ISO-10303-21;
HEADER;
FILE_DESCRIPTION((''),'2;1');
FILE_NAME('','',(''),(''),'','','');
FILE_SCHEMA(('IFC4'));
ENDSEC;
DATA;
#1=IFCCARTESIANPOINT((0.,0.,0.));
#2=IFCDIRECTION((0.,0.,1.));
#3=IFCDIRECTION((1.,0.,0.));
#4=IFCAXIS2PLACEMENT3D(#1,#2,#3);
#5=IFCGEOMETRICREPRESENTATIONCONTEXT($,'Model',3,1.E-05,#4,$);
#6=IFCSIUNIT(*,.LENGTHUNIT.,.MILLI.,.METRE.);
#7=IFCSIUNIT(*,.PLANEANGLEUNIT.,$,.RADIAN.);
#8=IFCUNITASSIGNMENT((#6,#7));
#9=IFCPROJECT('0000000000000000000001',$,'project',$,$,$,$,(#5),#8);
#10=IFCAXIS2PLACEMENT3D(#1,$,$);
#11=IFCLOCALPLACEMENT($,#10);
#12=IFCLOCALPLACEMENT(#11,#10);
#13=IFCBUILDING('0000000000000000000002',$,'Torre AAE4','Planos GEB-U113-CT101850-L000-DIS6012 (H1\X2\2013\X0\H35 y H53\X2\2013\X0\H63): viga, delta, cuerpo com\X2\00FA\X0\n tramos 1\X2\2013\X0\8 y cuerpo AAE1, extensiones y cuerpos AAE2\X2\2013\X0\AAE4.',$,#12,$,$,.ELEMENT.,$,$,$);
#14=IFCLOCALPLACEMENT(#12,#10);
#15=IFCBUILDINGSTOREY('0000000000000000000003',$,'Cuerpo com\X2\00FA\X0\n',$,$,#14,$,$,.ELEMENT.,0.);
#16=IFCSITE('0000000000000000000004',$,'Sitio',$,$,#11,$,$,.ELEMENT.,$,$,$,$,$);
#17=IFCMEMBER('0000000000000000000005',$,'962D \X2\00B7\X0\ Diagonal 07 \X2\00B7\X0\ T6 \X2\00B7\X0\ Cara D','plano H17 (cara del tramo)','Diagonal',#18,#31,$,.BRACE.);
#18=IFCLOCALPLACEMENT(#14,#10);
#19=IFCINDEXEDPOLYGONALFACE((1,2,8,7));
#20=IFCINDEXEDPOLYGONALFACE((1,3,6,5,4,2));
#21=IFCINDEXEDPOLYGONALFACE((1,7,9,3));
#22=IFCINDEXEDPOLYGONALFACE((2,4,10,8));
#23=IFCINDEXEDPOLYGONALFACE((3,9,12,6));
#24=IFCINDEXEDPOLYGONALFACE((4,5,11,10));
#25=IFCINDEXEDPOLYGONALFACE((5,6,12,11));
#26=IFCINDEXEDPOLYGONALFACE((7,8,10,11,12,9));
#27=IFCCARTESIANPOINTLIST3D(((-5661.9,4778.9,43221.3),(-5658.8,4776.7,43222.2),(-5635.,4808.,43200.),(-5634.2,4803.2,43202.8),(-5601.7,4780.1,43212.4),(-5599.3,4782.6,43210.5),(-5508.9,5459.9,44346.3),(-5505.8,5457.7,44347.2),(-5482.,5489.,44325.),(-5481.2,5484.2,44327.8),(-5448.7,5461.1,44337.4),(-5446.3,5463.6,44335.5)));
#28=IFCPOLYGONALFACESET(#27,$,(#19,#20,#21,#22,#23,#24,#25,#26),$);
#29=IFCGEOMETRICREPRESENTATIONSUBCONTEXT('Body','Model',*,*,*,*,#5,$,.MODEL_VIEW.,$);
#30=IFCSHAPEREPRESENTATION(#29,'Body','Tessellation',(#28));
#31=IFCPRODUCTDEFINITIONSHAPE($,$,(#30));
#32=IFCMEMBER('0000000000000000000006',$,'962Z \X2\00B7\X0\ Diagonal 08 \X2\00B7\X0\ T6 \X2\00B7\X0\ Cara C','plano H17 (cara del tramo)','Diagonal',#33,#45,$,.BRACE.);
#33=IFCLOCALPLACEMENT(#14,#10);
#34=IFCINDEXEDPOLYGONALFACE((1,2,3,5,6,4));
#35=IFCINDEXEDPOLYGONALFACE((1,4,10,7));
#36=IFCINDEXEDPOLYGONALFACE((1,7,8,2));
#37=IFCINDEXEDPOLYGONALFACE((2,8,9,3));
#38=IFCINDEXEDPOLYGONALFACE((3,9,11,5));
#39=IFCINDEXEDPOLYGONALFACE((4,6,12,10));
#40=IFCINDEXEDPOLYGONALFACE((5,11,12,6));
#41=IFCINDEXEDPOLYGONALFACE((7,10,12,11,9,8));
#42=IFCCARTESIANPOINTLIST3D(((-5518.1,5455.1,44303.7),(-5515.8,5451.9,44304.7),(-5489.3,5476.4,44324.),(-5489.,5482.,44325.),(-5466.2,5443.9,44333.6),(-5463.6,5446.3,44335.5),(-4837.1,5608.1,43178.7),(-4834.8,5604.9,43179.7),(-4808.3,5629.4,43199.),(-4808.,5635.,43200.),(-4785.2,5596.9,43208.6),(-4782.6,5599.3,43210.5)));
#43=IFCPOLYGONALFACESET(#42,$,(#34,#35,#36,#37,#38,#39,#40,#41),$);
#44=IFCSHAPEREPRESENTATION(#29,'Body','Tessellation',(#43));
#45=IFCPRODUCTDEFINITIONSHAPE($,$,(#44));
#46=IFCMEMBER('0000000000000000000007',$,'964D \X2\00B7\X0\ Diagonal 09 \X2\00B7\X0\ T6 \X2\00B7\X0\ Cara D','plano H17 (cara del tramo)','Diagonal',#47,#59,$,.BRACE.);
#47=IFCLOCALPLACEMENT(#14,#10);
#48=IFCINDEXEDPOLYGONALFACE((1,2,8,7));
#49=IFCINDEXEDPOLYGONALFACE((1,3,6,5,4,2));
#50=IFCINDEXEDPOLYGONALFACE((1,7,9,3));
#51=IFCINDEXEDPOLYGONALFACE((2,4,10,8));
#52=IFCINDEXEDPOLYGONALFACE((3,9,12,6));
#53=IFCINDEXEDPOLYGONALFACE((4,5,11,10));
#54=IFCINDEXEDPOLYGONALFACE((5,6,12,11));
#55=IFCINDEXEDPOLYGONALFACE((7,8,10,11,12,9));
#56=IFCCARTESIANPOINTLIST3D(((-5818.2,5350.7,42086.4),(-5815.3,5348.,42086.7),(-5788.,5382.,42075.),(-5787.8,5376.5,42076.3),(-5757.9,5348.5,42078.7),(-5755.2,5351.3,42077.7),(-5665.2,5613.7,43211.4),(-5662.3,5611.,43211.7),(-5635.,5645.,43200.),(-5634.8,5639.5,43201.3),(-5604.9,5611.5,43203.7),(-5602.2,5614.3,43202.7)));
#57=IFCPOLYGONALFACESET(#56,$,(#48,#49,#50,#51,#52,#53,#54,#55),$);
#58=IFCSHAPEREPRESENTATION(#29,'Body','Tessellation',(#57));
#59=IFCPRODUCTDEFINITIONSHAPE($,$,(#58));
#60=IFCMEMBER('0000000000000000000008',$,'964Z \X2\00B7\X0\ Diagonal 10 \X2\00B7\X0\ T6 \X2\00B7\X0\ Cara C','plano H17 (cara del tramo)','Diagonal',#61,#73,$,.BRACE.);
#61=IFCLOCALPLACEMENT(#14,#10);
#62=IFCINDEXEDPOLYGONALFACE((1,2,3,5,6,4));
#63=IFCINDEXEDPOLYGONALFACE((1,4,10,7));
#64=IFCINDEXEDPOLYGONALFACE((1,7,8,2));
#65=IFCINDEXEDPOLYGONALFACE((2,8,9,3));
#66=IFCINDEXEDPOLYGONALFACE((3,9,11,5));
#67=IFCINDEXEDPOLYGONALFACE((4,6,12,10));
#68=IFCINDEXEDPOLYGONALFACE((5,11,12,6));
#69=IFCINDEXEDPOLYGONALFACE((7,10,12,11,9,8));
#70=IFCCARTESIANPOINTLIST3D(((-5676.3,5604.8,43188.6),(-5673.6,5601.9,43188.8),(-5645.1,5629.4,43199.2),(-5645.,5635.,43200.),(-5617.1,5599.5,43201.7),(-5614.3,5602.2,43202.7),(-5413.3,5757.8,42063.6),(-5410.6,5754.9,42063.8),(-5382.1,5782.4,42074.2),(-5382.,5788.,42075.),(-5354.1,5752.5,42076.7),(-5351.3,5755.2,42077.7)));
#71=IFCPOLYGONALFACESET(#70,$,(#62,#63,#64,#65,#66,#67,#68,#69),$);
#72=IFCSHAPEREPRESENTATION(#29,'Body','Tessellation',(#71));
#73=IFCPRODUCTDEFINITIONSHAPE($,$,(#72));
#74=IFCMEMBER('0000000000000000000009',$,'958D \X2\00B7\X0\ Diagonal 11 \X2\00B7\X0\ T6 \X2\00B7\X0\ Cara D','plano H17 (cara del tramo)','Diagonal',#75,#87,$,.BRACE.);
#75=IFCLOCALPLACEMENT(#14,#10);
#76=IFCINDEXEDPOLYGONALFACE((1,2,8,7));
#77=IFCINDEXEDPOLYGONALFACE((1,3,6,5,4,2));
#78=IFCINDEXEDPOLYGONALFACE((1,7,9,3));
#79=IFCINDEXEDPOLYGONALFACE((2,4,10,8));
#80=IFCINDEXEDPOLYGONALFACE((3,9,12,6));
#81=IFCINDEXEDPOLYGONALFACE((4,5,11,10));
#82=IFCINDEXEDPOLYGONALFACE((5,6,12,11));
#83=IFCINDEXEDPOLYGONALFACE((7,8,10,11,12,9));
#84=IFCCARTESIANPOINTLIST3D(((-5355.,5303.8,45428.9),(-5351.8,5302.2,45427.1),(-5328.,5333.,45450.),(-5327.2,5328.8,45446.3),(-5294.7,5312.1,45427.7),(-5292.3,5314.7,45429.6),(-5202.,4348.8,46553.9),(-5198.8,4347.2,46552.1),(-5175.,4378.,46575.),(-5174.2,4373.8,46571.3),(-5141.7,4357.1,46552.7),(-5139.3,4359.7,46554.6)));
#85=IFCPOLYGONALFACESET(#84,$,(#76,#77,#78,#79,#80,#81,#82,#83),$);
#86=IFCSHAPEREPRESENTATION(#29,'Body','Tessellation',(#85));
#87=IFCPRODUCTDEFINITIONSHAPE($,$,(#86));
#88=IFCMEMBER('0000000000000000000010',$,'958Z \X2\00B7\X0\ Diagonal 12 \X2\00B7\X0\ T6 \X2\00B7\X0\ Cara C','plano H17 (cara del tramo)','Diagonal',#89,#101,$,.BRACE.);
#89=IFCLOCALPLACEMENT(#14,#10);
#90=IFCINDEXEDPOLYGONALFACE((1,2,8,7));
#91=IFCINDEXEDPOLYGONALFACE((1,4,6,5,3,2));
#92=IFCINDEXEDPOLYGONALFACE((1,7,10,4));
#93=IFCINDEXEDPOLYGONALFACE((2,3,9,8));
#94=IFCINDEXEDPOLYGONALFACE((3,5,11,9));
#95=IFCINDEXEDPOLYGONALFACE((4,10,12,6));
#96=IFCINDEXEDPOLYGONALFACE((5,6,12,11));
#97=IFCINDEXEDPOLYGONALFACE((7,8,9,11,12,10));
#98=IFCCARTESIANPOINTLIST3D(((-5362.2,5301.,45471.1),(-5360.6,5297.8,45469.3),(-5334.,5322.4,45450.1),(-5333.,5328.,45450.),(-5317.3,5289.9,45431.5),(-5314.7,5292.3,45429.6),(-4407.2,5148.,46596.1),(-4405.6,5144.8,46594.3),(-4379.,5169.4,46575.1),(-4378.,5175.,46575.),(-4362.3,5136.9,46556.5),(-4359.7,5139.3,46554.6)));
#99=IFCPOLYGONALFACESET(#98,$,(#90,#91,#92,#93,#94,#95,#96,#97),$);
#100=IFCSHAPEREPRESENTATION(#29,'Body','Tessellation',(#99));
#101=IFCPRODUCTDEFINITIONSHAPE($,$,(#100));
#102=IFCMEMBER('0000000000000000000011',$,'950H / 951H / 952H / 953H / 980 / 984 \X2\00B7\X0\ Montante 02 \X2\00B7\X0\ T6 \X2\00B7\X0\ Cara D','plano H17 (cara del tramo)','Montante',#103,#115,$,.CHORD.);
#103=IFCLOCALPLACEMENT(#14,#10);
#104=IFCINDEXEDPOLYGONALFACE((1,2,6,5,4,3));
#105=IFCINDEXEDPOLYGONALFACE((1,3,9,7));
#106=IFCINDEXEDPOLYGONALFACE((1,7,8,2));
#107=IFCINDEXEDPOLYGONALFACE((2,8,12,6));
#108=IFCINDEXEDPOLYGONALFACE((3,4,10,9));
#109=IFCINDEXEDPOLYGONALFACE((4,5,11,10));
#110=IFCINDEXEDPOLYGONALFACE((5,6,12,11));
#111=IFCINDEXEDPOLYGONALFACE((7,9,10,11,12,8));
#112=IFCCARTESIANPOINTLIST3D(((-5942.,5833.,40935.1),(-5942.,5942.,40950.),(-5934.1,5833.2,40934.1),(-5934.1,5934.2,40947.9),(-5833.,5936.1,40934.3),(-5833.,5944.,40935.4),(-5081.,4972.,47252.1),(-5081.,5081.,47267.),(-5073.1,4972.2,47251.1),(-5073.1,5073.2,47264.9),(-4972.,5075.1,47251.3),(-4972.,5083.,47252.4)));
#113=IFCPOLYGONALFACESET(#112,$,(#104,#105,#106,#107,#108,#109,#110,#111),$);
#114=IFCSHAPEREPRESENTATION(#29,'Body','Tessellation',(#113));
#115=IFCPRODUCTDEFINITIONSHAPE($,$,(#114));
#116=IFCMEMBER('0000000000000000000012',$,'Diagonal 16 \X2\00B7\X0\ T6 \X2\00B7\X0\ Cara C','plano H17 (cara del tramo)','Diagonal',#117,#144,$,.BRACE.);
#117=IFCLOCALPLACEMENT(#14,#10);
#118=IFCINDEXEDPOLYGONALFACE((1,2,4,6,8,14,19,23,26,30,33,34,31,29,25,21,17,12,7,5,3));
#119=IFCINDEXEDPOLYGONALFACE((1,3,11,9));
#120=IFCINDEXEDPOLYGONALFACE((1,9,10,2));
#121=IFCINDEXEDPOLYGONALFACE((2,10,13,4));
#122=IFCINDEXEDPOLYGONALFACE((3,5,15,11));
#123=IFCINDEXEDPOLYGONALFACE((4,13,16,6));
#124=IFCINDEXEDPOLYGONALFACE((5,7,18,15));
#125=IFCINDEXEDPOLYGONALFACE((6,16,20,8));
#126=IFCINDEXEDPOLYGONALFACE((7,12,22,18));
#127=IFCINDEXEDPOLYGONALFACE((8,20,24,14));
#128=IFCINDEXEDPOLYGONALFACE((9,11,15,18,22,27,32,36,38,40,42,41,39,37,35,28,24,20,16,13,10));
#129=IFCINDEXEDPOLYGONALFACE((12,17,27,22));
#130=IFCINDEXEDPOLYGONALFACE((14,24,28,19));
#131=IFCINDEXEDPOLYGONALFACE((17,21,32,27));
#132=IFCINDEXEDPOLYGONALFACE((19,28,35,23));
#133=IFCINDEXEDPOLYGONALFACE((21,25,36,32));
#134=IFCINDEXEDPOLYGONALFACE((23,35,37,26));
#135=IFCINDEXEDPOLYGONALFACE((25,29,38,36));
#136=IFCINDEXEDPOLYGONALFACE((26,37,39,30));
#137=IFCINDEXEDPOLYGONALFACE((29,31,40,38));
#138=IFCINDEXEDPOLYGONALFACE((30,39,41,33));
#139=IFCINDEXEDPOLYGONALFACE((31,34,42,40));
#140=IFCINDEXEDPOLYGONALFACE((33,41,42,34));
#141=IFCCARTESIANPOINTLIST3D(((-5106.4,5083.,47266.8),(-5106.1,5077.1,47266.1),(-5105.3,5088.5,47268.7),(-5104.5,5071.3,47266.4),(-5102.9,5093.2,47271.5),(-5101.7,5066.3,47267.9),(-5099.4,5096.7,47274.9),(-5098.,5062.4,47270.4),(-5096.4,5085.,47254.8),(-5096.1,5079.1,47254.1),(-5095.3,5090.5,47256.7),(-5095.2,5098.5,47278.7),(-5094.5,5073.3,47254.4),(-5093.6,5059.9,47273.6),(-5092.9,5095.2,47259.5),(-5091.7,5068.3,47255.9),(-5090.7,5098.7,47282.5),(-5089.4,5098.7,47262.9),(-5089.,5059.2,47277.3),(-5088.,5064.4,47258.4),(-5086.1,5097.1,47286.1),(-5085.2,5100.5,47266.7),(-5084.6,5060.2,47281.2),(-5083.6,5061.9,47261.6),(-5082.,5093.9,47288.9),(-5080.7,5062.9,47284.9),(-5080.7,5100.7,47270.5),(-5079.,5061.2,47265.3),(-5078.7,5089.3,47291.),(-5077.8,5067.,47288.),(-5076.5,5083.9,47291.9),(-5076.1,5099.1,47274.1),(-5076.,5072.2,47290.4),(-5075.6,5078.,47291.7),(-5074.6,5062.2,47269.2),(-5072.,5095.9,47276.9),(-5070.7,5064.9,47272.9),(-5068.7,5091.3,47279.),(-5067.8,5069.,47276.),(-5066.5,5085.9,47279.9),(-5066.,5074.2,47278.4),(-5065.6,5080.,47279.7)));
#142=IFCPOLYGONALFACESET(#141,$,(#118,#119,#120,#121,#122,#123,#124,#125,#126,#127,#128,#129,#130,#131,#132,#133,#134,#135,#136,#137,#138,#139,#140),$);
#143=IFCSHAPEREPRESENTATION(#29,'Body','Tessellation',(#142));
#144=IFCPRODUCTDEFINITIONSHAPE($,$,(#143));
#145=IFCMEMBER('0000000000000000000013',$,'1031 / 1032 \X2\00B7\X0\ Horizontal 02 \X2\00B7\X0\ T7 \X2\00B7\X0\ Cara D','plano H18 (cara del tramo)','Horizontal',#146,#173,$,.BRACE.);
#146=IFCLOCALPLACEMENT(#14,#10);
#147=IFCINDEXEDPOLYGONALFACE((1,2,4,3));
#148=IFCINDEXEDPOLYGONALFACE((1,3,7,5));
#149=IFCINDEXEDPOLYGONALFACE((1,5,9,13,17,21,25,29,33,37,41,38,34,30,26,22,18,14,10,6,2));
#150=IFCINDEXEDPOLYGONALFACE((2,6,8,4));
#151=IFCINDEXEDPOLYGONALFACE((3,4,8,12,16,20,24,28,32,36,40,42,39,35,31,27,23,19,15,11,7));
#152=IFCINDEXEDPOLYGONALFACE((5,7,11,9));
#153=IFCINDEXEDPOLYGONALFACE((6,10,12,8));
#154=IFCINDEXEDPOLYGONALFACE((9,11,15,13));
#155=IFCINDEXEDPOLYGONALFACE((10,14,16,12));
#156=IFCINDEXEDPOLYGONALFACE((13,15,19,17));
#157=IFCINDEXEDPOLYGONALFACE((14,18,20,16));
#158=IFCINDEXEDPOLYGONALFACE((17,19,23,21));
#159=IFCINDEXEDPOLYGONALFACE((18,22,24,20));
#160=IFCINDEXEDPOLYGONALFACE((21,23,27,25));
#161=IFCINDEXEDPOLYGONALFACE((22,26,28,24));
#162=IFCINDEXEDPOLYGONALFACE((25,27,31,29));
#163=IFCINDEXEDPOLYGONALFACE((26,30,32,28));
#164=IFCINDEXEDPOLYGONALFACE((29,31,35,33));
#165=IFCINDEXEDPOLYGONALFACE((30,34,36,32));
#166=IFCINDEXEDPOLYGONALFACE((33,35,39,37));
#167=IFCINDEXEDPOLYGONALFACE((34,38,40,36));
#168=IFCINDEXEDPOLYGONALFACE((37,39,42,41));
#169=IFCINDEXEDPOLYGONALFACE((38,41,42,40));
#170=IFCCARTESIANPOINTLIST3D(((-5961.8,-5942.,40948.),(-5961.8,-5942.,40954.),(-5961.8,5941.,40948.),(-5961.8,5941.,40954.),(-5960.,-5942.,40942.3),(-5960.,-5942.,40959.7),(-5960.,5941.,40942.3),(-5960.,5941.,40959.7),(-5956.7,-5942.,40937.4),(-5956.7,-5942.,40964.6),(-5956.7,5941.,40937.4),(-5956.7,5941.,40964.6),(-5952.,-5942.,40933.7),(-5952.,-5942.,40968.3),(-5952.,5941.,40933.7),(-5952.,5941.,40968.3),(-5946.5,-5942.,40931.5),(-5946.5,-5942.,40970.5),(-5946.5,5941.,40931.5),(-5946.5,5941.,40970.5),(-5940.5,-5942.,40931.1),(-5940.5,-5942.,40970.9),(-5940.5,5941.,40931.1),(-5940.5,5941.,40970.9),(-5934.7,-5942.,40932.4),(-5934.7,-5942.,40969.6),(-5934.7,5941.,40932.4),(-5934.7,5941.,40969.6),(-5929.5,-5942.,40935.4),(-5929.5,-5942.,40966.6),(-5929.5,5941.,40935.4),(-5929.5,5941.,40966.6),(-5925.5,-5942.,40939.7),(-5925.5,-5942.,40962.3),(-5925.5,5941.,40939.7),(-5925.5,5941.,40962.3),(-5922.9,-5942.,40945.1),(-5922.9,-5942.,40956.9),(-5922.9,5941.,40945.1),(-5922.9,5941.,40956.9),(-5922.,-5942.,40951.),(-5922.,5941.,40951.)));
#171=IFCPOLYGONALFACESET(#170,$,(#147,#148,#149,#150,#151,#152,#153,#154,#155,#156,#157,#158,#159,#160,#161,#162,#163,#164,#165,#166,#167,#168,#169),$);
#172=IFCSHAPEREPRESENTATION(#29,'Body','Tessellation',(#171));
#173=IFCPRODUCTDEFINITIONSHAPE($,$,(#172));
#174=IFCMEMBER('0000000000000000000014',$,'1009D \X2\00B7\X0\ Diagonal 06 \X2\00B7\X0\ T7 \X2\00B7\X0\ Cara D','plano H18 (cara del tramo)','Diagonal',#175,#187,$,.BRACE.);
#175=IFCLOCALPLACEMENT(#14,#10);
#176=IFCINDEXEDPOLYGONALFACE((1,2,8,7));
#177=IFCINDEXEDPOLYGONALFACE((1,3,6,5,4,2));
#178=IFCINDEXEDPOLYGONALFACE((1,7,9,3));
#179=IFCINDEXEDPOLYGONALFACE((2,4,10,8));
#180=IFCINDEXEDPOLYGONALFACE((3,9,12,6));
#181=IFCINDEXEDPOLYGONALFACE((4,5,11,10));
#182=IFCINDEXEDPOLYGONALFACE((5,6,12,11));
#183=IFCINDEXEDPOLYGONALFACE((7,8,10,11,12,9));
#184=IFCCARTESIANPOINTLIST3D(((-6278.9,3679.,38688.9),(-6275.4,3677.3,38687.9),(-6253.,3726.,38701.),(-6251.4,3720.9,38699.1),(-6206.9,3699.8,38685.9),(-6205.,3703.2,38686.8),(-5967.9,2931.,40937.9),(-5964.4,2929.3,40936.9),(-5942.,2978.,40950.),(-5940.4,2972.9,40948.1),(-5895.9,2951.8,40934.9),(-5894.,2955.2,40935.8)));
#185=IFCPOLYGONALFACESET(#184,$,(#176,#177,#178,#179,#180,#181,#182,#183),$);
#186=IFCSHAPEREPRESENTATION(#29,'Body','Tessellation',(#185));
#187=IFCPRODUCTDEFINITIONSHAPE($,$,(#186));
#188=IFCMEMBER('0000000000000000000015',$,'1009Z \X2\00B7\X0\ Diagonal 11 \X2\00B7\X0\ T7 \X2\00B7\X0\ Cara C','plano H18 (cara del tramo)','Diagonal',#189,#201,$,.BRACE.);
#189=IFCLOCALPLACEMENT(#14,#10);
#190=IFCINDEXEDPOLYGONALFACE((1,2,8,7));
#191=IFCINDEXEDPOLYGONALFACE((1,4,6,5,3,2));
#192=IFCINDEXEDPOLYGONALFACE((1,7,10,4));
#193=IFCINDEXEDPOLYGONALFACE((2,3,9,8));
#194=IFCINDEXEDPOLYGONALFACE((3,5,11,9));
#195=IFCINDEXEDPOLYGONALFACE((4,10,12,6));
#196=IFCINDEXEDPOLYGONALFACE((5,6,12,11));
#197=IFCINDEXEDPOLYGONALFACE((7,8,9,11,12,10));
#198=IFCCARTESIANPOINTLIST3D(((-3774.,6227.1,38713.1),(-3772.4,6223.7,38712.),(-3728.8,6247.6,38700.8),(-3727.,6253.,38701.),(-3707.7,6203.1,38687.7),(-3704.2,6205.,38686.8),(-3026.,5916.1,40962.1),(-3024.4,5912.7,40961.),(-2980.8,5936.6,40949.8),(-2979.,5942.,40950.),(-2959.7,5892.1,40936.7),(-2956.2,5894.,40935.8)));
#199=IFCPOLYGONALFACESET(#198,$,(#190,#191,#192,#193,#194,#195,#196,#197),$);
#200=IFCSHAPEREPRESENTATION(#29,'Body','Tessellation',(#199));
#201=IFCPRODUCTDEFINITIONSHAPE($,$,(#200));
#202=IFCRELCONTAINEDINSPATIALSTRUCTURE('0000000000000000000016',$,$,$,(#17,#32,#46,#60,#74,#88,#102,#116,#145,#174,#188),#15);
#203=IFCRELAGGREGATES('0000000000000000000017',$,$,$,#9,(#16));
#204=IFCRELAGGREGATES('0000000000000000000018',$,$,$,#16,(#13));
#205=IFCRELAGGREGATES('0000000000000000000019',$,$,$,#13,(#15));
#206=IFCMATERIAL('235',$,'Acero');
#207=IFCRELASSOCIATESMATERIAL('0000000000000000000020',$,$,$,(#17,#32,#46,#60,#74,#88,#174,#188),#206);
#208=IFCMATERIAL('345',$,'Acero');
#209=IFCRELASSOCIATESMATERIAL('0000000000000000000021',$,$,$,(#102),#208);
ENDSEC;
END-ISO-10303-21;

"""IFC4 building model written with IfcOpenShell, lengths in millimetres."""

from ifc_helpers import new_model, si_unit, frame, frame_2d, origin, origin_with_axes, place, context, subcontext, project, spatial, circle, l_section, extrude, material, element, save


model = new_model("IFC4")

# Units and contexts
model_context = context("Model", 3, precision=1e-05, world=origin_with_axes())
body_context = subcontext(model_context, "Body", "Model", "MODEL_VIEW")
ifc_project = project(units=[si_unit("LENGTHUNIT", "METRE", prefix="MILLI"), si_unit("PLANEANGLEUNIT", "RADIAN")], contexts=[model_context])

# Site, building, storey
site_placement = place(None, origin())
site = spatial("IfcSite", under=ifc_project, at=site_placement, Name="Sitio", CompositionType="ELEMENT")
building_placement = place(site_placement, origin())
building = spatial("IfcBuilding", under=site, at=building_placement, Name="Torre AAE4", Description="Planos GEB-U113-CT101850-L000-DIS6012 (H1–H35 y H53–H63): viga, delta, cuerpo común tramos 1–8 y cuerpo AAE1, extensiones y cuerpos AAE2–AAE4.", CompositionType="ELEMENT")
storey_placement = place(building_placement, origin())
storey = spatial("IfcBuildingStorey", under=building, at=storey_placement, Name="Cuerpo común", CompositionType="ELEMENT", Elevation=0.0)

# Members
ifc_material_1 = material(Name="235", Category="Acero")
for number, where, z_axis, x_axis, name in (
    (1, (-5482.0, 5489.0, 44325.0), (-0.115565, -0.514377, -0.849742), (0.792522, -0.563456, 0.233295), "962D · Diagonal 07 · T6 · Cara D"),
    (2, (-5489.0, 5482.0, 44325.0), (0.514377, 0.115565, -0.849742), (0.563456, -0.792522, 0.233295), "962Z · Diagonal 08 · T6 · Cara C"),
):
    element("IfcMember", number, at=place(storey_placement, frame(where, z_axis=z_axis, x_axis=x_axis)), inside=storey, material=ifc_material_1, Name=name, Description="plano H17 (cara del tramo)", ObjectType="Diagonal", PredefinedType="BRACE", context=body_context, shape_type="SweptSolid", body=[
        extrude(l_section(Depth=45.0, Width=45.0, Thickness=4.0, at=frame_2d((22.5, 22.5))), None, (0.0, 0.0, 1.0), 1323.9),
    ])
for number, where, z_axis, x_axis, name in (
    (3, (-5635.0, 5645.0, 43200.0), (-0.131283, -0.22567, -0.965318), (0.729059, -0.681795, 0.060236), "964D · Diagonal 09 · T6 · Cara D"),
    (4, (-5645.0, 5635.0, 43200.0), (0.22567, 0.131283, -0.965318), (0.681795, -0.729059, 0.060236), "964Z · Diagonal 10 · T6 · Cara C"),
):
    element("IfcMember", number, at=place(storey_placement, frame(where, z_axis=z_axis, x_axis=x_axis)), inside=storey, material=ifc_material_1, Name=name, Description="plano H17 (cara del tramo)", ObjectType="Diagonal", PredefinedType="BRACE", context=body_context, shape_type="SweptSolid", body=[
        extrude(l_section(Depth=45.0, Width=45.0, Thickness=4.0, at=frame_2d((22.5, 22.5))), None, (0.0, 0.0, 1.0), 1165.4),
    ])
for number, where, z_axis, x_axis, name in (
    (5, (-5175.0, 4378.0, 46575.0), (-0.103128, 0.643706, -0.758292), (0.793627, -0.40631, -0.452845), "958D · Diagonal 11 · T6 · Cara D"),
    (6, (-4378.0, 5175.0, 46575.0), (-0.643706, 0.103128, -0.758292), (0.40631, -0.793627, -0.452845), "958Z · Diagonal 12 · T6 · Cara C"),
):
    element("IfcMember", number, at=place(storey_placement, frame(where, z_axis=z_axis, x_axis=x_axis)), inside=storey, material=ifc_material_1, Name=name, Description="plano H17 (cara del tramo)", ObjectType="Diagonal", PredefinedType="BRACE", context=body_context, shape_type="SweptSolid", body=[
        extrude(l_section(Depth=45.0, Width=45.0, Thickness=4.0, at=frame_2d((22.5, 22.5))), None, (0.0, 0.0, 1.0), 1483.6),
    ])
ifc_material_2 = material(Name="345", Category="Acero")
member_1_placement = place(storey_placement, frame((-5081.0, 5081.0, 47267.0), z_axis=(-0.133835, 0.133835, -0.981925), x_axis=(0.991004, 0.018074, -0.132609)))
element("IfcMember", 7, at=member_1_placement, inside=storey, material=ifc_material_2, Name="950H / 951H / 952H / 953H / 980 / 984 · Montante 02 · T6 · Cara D", Description="plano H17 (cara del tramo)", ObjectType="Montante", PredefinedType="CHORD", context=body_context, shape_type="SweptSolid", body=[
    extrude(l_section(Depth=110.0, Width=110.0, Thickness=8.0, at=frame_2d((55.0, 55.0))), None, (0.0, 0.0, 1.0), 6433.3),
])
member_2_placement = place(storey_placement, frame((-5091.0, 5079.0, 47279.0), z_axis=(0.635001, 0.127, -0.762001), x_axis=(0.513563, -0.806261, 0.293592)))
element("IfcMember", 8, at=member_2_placement, inside=storey, Name="Diagonal 16 · T6 · Cara C", Description="plano H17 (cara del tramo)", ObjectType="Diagonal", PredefinedType="BRACE", context=body_context, shape_type="SweptSolid", body=[
    extrude(circle(Radius=20.0), None, (0.0, 0.0, 1.0), 15.7),
])
member_3_placement = place(storey_placement, frame((-5942.0, 5941.0, 40951.0), z_axis=(0.0, -1.0, 0.0), x_axis=(1.0, 0.0, 0.0)))
element("IfcMember", 9, at=member_3_placement, inside=storey, Name="1031 / 1032 · Horizontal 02 · T7 · Cara D", Description="plano H18 (cara del tramo)", ObjectType="Horizontal", PredefinedType="BRACE", context=body_context, shape_type="SweptSolid", body=[
    extrude(circle(Radius=20.0), None, (0.0, 0.0, 1.0), 11883.0),
])
for number, where, z_axis, x_axis, name in (
    (10, (-5942.0, 2978.0, 40950.0), (-0.130101, 0.312912, -0.940829), (0.873022, -0.413656, -0.258304), "1009D · Diagonal 06 · T7 · Cara D"),
    (11, (-2979.0, 5942.0, 40950.0), (-0.312912, 0.130101, -0.940829), (0.413765, -0.872962, -0.258331), "1009Z · Diagonal 11 · T7 · Cara C"),
):
    element("IfcMember", number, at=place(storey_placement, frame(where, z_axis=z_axis, x_axis=x_axis)), inside=storey, material=ifc_material_1, Name=name, Description="plano H18 (cara del tramo)", ObjectType="Diagonal", PredefinedType="BRACE", context=body_context, shape_type="SweptSolid", body=[
        extrude(l_section(Depth=55.0, Width=55.0, Thickness=4.0, at=frame_2d((27.5, 27.5))), None, (0.0, 0.0, 1.0), 2390.4),
    ])

save(model, "model.ifc")
